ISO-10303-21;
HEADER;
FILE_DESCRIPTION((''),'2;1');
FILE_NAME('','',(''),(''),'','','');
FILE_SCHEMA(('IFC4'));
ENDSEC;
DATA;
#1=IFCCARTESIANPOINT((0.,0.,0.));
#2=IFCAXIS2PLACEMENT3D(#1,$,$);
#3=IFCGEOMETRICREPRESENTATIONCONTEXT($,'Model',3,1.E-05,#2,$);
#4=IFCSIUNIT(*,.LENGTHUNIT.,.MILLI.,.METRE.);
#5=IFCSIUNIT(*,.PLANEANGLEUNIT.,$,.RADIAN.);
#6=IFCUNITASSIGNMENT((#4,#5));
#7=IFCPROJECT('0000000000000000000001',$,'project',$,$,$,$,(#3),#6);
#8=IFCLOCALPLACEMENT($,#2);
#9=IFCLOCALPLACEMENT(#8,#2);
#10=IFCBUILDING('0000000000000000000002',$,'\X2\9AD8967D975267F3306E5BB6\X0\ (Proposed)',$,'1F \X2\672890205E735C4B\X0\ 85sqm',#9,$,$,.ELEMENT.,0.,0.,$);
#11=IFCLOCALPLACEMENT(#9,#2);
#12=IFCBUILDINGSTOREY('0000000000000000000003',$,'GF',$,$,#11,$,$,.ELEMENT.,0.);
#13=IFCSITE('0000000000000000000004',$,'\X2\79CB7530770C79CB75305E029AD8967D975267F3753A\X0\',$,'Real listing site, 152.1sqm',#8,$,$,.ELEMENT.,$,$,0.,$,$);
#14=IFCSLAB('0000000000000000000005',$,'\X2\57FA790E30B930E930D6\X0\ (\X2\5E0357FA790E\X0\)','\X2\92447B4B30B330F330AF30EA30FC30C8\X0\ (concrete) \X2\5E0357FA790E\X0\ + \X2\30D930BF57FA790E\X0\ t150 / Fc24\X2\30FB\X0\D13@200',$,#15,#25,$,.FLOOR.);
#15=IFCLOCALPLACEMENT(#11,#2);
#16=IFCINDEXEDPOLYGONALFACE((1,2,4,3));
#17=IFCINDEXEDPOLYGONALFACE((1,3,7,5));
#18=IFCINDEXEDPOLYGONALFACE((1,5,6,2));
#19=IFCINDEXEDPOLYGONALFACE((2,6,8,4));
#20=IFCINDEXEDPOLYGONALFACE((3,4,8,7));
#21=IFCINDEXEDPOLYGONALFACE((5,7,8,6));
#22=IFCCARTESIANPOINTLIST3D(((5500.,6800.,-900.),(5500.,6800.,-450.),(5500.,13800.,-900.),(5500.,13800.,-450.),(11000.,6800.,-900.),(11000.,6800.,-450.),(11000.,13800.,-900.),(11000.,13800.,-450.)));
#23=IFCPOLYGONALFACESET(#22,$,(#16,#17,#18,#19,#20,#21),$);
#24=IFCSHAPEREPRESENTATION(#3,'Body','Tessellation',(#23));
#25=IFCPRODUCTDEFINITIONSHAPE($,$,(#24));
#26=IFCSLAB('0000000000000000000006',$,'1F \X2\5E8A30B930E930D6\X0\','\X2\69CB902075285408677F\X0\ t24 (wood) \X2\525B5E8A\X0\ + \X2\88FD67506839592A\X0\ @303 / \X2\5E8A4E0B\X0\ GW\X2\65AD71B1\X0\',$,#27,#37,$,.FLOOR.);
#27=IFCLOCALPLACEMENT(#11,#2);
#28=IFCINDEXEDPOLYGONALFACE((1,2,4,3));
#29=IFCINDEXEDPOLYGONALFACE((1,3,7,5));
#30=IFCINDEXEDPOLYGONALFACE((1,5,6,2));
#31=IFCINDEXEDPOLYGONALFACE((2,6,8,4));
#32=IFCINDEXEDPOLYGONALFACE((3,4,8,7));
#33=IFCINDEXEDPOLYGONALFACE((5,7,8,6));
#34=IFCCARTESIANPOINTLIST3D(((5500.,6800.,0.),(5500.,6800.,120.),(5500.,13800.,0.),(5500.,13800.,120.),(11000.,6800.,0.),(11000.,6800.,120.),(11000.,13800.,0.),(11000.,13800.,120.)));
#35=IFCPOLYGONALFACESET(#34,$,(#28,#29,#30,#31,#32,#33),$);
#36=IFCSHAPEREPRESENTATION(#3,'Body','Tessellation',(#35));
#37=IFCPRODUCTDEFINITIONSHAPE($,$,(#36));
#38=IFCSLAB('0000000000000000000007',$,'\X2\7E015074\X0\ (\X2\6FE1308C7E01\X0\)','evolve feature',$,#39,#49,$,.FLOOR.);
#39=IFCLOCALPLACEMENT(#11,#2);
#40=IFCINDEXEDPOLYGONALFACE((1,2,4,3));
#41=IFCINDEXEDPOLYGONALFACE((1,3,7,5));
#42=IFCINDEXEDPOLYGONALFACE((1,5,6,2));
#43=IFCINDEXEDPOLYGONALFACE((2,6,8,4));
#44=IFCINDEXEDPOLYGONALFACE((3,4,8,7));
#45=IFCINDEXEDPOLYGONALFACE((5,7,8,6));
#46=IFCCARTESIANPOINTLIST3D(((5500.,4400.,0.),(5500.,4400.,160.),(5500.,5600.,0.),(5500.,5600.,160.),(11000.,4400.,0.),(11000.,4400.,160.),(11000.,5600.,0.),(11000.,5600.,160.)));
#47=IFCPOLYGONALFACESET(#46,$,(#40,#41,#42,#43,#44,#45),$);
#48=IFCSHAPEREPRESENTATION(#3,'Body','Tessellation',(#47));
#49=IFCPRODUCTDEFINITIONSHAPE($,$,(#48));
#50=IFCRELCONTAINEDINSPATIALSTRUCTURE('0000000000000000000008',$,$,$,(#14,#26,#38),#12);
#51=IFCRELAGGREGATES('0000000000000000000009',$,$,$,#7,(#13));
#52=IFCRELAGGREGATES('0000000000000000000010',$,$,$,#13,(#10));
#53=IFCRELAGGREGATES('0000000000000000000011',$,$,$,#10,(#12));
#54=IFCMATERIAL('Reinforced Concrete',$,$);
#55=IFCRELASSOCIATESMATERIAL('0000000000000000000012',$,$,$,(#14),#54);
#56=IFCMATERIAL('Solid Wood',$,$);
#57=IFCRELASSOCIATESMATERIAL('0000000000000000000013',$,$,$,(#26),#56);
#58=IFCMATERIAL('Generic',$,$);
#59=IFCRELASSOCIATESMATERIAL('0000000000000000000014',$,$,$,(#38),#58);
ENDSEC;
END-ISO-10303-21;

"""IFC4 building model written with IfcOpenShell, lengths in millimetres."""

from ifc_helpers import new_model, si_unit, frame, frame_2d, origin, place, context, project, spatial, rectangle, extrude, material, element, save


model = new_model("IFC4")

# Units and contexts
model_context = context("Model", 3, precision=1e-05, world=origin())
ifc_project = project(units=[si_unit("LENGTHUNIT", "METRE", prefix="MILLI"), si_unit("PLANEANGLEUNIT", "RADIAN")], contexts=[model_context])

# Site, building, storey
site_placement = place(None, origin())
site = spatial("IfcSite", under=ifc_project, at=site_placement, Name="秋田県秋田市高陽青柳町", ObjectType="Real listing site, 152.1sqm", CompositionType="ELEMENT", RefElevation=0.0)
building_placement = place(site_placement, origin())
building = spatial("IfcBuilding", under=site, at=building_placement, Name="高陽青柳の家 (Proposed)", ObjectType="1F 木造平屋 85sqm", CompositionType="ELEMENT", ElevationOfRefHeight=0.0, ElevationOfTerrain=0.0)
storey_placement = place(building_placement, origin())
storey = spatial("IfcBuildingStorey", under=building, at=storey_placement, Name="GF", CompositionType="ELEMENT", Elevation=0.0)

# Slabs
ifc_material_1 = material(Name="Reinforced Concrete")
slab_1_placement = place(storey_placement, frame((2750.0, 3400.0, -450.0)))
element("IfcSlab", 1, at=slab_1_placement, inside=storey, material=ifc_material_1, Name="基礎スラブ (布基礎)", Description="鉄筋コンクリート (concrete) 布基礎 + ベタ基礎 t150 / Fc24・D13@200", PredefinedType="FLOOR", context=model_context, shape_type="SweptSolid", body=[
    extrude(rectangle(XDim=5500.0, YDim=7000.0, at=frame_2d((2750.0, 3500.0))), frame((2750.0, 3400.0, -450.0)), (0.0, 0.0, 1.0), 450.0),
])
ifc_material_2 = material(Name="Solid Wood")
slab_2_placement = place(storey_placement, frame((2750.0, 3400.0, 0.0)))
element("IfcSlab", 2, at=slab_2_placement, inside=storey, material=ifc_material_2, Name="1F 床スラブ", Description="構造用合板 t24 (wood) 剛床 + 製材根太 @303 / 床下 GW断熱", PredefinedType="FLOOR", context=model_context, shape_type="SweptSolid", body=[
    extrude(rectangle(XDim=5500.0, YDim=7000.0, at=frame_2d((2750.0, 3500.0))), frame((2750.0, 3400.0, 0.0)), (0.0, 0.0, 1.0), 120.0),
])
ifc_material_3 = material(Name="Generic")
slab_3_placement = place(storey_placement, frame((2750.0, 2200.0, 0.0)))
element("IfcSlab", 3, at=slab_3_placement, inside=storey, material=ifc_material_3, Name="縁側 (濡れ縁)", Description="evolve feature", PredefinedType="FLOOR", context=model_context, shape_type="SweptSolid", body=[
    extrude(rectangle(XDim=5500.0, YDim=1200.0, at=frame_2d((2750.0, 600.0))), frame((2750.0, 2200.0, 0.0)), (0.0, 0.0, 1.0), 160.0),
])

save(model, "model.ifc")
